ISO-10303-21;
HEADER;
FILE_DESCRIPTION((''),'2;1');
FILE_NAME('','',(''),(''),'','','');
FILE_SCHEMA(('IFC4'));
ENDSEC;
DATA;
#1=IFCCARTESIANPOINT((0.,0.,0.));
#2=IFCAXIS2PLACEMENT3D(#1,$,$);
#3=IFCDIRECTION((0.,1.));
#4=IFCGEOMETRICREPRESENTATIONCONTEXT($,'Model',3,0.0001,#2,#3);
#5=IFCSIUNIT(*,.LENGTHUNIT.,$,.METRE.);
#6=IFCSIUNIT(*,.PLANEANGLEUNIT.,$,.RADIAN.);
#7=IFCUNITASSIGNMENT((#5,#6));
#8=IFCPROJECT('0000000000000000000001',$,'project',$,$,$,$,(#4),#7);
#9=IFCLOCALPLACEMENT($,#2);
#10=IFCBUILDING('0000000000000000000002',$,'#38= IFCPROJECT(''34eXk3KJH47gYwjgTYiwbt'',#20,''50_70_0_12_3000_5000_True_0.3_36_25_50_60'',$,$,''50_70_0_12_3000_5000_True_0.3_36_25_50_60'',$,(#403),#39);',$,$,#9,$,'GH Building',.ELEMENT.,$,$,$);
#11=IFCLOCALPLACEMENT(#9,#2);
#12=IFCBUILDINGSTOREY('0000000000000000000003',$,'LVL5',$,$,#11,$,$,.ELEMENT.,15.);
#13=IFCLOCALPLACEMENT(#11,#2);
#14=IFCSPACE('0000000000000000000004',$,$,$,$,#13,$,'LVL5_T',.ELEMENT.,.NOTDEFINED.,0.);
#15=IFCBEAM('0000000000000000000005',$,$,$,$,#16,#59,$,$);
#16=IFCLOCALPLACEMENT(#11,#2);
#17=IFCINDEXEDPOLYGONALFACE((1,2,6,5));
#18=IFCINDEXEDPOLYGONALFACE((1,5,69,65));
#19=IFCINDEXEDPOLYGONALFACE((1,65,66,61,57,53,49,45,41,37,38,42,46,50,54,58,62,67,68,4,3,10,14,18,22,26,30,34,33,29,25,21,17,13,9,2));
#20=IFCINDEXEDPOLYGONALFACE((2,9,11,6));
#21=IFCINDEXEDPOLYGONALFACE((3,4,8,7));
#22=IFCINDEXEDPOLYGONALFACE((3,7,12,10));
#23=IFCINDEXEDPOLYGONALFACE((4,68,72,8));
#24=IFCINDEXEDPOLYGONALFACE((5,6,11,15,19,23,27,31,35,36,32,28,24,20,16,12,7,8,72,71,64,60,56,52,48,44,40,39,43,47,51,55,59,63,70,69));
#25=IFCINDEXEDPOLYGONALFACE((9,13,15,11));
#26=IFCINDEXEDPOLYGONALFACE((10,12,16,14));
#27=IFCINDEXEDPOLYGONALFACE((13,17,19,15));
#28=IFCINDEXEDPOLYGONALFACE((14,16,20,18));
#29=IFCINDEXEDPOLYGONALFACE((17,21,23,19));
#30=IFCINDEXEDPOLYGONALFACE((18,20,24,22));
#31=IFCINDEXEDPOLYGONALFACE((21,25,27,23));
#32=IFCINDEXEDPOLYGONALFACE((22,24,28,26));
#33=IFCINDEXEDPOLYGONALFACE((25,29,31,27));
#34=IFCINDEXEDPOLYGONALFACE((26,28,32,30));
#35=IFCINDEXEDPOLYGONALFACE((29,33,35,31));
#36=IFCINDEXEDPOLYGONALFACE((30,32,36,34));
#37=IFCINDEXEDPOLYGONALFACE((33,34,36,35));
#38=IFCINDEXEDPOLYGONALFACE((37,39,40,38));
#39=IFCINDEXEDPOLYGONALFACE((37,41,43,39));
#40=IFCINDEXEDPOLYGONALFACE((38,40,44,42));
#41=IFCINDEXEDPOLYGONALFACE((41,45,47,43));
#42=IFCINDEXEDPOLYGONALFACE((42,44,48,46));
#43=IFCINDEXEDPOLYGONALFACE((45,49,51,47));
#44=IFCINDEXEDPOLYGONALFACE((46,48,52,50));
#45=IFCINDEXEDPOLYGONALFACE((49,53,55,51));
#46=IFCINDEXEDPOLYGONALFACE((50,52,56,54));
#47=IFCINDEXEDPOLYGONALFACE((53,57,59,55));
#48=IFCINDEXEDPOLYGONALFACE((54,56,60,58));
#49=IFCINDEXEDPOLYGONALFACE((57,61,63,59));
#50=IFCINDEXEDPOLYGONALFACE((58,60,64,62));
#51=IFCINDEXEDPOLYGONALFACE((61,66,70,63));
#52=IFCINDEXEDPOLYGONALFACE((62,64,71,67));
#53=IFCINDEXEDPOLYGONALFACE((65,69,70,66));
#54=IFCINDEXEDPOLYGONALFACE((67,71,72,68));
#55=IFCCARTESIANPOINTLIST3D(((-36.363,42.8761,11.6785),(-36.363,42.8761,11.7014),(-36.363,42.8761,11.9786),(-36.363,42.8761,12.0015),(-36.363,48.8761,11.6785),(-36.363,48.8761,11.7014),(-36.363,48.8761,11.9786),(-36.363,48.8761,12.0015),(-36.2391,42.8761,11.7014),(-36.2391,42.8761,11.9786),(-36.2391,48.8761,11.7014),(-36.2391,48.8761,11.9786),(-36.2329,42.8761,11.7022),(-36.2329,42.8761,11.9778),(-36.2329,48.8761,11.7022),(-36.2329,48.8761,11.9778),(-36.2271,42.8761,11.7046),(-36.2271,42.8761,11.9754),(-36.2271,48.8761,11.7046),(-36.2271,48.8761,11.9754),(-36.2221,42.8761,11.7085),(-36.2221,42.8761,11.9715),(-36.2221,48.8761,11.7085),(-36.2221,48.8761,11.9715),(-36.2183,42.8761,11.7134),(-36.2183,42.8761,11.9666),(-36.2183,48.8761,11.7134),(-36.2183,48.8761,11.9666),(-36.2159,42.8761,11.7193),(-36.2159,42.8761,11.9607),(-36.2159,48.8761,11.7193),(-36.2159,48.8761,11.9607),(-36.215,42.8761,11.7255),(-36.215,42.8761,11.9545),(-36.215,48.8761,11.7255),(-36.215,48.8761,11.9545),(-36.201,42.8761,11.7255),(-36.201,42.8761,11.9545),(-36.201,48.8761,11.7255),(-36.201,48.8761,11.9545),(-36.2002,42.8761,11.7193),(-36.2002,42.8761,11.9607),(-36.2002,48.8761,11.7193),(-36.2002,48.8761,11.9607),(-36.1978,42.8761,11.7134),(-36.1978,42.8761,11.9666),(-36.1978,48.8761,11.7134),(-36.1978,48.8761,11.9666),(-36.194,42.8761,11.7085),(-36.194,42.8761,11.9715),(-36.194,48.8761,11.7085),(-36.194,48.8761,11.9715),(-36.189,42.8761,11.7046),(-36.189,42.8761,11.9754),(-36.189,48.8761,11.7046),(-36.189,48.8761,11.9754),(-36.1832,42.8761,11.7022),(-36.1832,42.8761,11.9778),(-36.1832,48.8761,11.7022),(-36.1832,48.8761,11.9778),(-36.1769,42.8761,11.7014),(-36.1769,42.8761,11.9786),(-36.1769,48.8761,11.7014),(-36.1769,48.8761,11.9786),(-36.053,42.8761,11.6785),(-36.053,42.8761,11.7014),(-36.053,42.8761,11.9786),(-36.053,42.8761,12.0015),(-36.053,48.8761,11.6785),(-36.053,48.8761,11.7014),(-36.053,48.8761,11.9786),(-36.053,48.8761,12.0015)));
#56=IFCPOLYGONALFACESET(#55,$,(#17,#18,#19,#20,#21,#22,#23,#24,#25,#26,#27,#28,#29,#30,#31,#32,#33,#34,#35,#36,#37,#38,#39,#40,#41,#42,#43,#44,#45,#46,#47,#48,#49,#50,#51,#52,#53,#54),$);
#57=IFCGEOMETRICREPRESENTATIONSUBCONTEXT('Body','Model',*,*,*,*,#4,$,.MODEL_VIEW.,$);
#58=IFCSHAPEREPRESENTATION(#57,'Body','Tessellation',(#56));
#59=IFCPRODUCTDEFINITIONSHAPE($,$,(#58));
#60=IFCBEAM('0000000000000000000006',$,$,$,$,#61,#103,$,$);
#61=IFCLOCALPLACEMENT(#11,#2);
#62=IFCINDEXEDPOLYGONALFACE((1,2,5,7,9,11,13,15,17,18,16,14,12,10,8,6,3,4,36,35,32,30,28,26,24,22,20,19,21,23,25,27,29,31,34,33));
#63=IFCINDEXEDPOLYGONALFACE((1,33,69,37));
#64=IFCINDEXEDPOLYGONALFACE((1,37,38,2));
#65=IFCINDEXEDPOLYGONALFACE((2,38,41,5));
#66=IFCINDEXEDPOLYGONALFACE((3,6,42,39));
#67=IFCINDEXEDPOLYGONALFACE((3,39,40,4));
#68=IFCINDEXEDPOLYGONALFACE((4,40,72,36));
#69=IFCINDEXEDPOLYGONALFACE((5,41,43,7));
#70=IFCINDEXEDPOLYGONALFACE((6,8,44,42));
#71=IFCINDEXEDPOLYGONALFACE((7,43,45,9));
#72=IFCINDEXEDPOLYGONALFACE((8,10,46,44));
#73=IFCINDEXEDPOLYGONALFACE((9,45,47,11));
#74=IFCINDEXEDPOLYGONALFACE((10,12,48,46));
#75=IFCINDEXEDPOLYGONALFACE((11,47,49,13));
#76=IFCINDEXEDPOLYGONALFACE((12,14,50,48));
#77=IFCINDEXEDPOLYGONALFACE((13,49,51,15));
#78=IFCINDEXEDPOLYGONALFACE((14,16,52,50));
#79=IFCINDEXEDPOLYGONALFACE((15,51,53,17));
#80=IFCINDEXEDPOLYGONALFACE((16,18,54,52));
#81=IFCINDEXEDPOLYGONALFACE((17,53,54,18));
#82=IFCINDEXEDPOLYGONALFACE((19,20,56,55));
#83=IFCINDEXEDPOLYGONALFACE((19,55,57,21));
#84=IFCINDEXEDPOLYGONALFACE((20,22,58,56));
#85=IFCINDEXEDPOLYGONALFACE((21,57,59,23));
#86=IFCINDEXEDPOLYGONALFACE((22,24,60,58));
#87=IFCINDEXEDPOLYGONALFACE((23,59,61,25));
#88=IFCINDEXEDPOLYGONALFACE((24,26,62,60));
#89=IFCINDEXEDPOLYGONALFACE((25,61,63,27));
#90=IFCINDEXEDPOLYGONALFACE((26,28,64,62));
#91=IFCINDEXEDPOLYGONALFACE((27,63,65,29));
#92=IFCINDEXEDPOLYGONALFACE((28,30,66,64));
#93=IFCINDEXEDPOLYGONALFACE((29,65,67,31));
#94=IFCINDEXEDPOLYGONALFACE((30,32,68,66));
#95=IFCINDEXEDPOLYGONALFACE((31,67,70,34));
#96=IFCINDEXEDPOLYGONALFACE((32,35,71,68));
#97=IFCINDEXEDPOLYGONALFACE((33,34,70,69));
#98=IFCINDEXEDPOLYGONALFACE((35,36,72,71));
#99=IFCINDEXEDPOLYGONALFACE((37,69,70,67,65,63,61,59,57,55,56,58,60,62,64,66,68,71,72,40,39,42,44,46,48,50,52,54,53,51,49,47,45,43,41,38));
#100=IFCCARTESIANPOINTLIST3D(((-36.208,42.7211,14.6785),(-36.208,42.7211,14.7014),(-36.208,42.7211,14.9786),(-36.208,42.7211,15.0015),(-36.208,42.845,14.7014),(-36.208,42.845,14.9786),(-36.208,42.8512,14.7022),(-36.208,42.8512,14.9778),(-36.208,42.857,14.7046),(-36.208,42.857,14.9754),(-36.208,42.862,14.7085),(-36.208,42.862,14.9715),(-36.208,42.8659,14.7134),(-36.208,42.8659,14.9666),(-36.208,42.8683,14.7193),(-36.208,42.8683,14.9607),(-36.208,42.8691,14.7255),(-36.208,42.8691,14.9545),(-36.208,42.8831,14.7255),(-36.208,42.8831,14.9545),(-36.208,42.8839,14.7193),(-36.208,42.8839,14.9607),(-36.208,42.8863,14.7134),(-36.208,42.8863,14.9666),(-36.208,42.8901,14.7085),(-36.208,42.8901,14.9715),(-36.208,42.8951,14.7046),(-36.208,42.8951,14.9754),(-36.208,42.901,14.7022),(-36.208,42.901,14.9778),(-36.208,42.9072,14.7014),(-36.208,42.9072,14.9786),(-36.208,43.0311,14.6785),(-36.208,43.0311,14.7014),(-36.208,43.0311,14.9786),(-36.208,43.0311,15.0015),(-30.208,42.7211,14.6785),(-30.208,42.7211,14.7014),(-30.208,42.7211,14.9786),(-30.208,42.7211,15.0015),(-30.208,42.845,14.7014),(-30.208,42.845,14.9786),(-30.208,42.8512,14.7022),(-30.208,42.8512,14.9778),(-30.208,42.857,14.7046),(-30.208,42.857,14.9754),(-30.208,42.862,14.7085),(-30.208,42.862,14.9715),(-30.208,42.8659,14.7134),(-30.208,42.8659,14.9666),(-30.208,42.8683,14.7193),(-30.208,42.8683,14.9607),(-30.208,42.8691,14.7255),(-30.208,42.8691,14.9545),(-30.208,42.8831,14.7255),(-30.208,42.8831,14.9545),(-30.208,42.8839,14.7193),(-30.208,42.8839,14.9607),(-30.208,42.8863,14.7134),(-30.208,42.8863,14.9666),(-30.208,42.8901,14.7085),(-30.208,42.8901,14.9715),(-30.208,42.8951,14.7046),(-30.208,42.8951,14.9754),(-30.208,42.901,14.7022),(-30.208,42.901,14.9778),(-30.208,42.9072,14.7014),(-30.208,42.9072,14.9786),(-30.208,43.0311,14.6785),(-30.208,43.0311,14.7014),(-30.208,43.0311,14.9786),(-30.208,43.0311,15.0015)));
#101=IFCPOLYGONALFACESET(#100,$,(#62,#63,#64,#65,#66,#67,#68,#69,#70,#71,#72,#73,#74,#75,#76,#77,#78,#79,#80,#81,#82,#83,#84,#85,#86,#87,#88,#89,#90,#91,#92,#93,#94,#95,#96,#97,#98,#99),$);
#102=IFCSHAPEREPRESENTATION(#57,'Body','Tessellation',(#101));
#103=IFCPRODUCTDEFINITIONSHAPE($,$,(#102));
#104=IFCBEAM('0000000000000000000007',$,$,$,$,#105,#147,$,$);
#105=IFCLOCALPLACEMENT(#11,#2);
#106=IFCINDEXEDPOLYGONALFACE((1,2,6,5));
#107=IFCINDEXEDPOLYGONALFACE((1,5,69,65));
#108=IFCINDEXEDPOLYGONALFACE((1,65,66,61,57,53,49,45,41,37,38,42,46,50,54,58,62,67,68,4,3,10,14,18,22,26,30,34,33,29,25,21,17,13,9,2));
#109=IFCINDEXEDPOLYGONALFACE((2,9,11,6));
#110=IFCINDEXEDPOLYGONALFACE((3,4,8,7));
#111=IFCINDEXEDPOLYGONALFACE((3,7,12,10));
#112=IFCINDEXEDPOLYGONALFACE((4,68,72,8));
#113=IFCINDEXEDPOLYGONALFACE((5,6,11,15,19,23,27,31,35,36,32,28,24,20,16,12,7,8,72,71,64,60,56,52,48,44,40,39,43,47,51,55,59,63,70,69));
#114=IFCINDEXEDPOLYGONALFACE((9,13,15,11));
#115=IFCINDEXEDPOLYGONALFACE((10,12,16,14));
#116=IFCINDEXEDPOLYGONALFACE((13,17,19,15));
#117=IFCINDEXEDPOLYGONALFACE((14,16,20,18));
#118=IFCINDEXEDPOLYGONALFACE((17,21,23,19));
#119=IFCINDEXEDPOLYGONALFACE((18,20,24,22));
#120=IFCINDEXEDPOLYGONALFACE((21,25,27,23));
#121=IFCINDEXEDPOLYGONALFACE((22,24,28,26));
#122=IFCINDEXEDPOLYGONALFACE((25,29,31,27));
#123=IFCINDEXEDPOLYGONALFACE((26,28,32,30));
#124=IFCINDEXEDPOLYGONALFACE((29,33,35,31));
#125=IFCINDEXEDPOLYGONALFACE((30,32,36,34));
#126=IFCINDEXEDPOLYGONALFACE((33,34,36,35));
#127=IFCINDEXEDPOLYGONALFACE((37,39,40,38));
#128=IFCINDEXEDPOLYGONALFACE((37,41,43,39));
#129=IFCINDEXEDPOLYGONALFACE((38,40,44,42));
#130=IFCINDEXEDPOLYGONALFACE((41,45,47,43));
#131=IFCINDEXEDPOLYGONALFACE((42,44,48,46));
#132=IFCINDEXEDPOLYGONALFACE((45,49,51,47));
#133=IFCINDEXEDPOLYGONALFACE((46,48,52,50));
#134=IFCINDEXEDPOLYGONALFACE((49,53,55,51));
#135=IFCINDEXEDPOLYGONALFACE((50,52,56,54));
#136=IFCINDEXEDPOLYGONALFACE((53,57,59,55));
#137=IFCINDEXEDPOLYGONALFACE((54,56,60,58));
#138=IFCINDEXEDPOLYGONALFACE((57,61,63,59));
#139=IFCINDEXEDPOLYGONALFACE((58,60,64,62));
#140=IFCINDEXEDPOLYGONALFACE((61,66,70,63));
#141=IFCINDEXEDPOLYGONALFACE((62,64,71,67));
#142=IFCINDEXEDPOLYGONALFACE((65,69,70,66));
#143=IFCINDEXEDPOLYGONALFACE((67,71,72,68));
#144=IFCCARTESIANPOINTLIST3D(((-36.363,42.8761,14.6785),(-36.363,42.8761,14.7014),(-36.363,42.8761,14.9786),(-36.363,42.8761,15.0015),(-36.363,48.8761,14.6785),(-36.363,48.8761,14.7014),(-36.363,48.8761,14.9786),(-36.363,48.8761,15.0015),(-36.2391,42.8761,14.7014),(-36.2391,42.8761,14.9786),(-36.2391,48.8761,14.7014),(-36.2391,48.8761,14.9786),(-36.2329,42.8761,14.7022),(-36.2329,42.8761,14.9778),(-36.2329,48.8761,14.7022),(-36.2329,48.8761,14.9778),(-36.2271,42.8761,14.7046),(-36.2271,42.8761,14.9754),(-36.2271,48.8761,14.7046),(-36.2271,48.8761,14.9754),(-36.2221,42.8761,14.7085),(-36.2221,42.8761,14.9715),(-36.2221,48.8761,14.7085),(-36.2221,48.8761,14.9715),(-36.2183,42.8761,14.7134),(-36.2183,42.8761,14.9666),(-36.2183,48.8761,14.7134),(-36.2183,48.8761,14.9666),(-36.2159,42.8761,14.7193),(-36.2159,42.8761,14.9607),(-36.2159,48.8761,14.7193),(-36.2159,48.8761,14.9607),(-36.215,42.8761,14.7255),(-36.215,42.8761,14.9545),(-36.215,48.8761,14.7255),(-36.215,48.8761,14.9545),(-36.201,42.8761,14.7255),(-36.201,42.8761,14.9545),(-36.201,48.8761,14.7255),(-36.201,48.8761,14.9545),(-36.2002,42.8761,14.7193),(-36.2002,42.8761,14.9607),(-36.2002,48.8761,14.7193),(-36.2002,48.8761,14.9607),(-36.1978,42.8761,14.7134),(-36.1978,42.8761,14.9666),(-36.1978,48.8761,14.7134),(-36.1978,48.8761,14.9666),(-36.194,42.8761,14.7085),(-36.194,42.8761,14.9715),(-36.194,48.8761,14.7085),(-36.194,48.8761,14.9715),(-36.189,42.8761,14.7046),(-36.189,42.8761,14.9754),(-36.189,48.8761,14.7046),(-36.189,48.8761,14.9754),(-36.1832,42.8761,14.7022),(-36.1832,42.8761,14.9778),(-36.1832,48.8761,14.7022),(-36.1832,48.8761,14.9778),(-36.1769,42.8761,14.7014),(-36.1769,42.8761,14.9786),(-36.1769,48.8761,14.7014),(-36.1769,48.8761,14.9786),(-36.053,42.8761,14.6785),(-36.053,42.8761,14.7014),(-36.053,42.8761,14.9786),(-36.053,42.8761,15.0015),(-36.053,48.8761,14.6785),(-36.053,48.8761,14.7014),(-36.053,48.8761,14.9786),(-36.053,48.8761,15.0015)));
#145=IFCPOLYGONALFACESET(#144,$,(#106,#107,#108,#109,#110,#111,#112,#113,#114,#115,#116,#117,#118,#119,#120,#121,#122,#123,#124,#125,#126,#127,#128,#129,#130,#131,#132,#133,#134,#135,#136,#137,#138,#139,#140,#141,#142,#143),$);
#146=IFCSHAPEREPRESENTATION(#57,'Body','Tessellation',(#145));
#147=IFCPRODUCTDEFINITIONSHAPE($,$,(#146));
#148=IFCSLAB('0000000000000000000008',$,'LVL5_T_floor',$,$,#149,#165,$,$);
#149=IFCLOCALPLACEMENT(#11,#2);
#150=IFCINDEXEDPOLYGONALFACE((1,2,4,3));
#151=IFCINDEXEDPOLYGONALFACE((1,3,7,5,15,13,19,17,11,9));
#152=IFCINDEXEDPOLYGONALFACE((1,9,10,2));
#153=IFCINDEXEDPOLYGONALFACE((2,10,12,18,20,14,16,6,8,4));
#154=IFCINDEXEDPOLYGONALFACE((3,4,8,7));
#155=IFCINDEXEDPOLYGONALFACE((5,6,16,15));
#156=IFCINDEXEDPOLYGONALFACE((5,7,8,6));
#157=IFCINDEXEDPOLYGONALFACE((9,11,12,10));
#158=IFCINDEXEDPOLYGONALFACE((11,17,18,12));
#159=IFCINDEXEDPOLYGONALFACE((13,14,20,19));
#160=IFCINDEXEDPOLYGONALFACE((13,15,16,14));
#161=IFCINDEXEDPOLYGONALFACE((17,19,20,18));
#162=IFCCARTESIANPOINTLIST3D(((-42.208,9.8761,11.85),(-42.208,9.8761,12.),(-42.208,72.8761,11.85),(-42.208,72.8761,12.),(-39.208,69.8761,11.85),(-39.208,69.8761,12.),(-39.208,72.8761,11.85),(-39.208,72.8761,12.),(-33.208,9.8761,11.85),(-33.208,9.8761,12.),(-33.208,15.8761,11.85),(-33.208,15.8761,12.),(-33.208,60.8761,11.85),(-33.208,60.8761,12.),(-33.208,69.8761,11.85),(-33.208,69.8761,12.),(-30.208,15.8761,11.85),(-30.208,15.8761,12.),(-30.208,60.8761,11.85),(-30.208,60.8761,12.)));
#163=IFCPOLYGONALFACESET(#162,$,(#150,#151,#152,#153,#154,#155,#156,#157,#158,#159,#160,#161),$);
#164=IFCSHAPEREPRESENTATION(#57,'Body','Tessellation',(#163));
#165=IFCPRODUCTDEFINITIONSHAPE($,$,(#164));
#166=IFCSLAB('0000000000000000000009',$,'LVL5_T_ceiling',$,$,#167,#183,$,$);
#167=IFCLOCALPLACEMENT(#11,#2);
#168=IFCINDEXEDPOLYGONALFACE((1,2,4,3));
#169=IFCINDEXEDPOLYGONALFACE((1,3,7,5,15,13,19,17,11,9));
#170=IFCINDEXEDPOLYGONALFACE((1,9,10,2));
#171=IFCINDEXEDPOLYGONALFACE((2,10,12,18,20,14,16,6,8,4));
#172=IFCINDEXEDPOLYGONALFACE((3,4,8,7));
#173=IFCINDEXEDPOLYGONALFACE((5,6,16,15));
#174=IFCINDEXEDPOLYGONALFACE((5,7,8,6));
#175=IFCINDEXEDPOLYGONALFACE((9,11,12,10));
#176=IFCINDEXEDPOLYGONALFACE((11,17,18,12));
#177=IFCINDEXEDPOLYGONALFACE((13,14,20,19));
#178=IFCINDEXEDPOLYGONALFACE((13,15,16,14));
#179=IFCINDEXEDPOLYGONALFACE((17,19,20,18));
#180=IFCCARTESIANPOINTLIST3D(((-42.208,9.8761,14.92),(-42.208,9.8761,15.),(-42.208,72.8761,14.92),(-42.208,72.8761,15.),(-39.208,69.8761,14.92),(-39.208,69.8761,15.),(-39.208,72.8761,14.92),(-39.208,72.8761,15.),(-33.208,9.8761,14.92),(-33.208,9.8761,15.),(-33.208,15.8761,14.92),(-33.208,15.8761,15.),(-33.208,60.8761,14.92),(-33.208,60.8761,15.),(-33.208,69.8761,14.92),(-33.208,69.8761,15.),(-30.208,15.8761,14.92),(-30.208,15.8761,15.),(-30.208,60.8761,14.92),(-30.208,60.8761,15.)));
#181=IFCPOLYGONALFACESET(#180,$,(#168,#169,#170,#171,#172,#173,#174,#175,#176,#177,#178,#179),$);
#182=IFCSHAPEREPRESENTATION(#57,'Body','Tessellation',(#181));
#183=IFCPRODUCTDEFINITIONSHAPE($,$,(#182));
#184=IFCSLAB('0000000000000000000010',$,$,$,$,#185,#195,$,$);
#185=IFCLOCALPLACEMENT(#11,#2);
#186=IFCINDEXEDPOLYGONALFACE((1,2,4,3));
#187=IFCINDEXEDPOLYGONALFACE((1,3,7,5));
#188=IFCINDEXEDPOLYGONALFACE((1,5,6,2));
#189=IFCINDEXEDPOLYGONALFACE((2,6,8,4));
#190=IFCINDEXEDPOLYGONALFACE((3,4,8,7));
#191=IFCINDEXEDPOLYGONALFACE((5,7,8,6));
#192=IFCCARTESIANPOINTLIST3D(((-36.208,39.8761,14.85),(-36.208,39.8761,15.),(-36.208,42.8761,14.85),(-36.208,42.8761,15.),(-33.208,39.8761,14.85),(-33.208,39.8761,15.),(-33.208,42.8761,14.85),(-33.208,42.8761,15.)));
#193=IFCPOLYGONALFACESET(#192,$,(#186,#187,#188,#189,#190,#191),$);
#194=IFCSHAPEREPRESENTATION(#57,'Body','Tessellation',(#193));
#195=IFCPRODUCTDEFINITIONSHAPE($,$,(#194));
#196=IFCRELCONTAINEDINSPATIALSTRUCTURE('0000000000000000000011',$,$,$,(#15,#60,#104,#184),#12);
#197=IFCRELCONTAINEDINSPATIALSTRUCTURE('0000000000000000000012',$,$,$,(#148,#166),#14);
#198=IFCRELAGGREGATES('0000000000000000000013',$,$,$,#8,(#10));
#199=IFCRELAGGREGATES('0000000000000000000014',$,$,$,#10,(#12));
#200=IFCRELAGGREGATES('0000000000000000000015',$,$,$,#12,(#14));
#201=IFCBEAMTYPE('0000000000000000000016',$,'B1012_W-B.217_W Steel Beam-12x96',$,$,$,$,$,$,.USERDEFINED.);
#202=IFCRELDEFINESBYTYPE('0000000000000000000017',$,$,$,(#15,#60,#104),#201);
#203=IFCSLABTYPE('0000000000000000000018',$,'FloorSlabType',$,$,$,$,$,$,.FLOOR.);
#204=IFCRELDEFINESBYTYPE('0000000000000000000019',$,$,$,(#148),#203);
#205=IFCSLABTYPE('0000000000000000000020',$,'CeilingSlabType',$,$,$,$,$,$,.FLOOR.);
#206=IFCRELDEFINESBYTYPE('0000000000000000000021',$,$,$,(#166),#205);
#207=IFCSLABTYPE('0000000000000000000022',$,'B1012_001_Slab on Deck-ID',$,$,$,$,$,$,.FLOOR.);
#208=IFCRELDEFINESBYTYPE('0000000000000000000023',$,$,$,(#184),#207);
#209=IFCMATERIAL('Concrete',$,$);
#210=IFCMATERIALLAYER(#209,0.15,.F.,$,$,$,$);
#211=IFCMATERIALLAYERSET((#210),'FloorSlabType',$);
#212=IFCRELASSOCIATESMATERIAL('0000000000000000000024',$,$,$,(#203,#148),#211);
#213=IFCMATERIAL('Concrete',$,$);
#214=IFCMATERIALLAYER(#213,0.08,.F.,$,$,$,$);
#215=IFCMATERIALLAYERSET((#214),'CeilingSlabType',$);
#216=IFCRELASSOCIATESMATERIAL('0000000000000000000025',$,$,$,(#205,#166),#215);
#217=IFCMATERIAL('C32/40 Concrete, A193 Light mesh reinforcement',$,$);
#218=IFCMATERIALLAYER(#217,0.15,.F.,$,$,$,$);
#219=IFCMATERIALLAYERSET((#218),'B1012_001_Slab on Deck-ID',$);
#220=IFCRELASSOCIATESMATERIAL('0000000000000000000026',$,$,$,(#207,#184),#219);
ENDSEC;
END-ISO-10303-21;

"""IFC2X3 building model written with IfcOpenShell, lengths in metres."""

from ifc_helpers import new_model, si_unit, direction, frame, origin, origin_2d, place, context, subcontext, project, spatial, polyline, i_section, outline, extrude, material, layer, layer_set, layer_usage, type_object, element, save


model = new_model("IFC2X3")

# Units and contexts
model_context = context("Model", 3, precision=0.0001, world=origin(), true_north=direction((0.0, 1.0)))
body_context = subcontext(model_context, "Body", "Model", "MODEL_VIEW")
ifc_project = project(units=[si_unit("LENGTHUNIT", "METRE"), si_unit("PLANEANGLEUNIT", "RADIAN")], contexts=[model_context])

# Building, storey, space
building_placement = place(None, origin())
building = spatial("IfcBuilding", under=ifc_project, at=building_placement, Name="#38= IFCPROJECT('34eXk3KJH47gYwjgTYiwbt',#20,'50_70_0_12_3000_5000_True_0.3_36_25_50_60',$,$,'50_70_0_12_3000_5000_True_0.3_36_25_50_60',$,(#403),#39);", LongName="GH Building", CompositionType="ELEMENT")
storey_placement = place(building_placement, origin())
storey = spatial("IfcBuildingStorey", under=building, at=storey_placement, Name="LVL5", CompositionType="ELEMENT", Elevation=15.0)
space_1_placement = place(storey_placement, origin())
space_1 = spatial("IfcSpace", under=storey, at=space_1_placement, LongName="LVL5_T", CompositionType="ELEMENT", InteriorOrExteriorSpace="NOTDEFINED", ElevationWithFlooring=0.0)

# Beams
beam_type = type_object("IfcBeamType", Name="B1012_W-B.217_W Steel Beam-12x96", PredefinedType="USERDEFINED")
for number, where, z_axis, x_axis in (
    (1, (-36.208, 42.8761, 11.84), (0.0, 1.0, 0.0), (-1.0, 0.0, 0.0)),
    (2, (-36.208, 42.8761, 14.84), (1.0, 0.0, 0.0), (0.0, 1.0, 0.0)),
    (3, (-36.208, 42.8761, 14.84), (0.0, 1.0, 0.0), (-1.0, 0.0, 0.0)),
):
    element("IfcBeam", number, at=place(storey_placement, frame(where, z_axis=z_axis, x_axis=x_axis)), inside=storey, type_object=beam_type, context=body_context, shape_type="SweptSolid", body=[
        extrude(i_section(OverallWidth=0.31, OverallDepth=0.323, WebThickness=0.014, FlangeThickness=0.0229, FilletRadius=0.0241, at=origin_2d()), origin(), (0.0, 0.0, 1.0), 6.0),
    ])

# Slabs
ifc_material_1 = material(Name="Concrete")
ifc_layer_1 = layer(ifc_material_1, 0.15, ventilated=False)
ifc_layer_set_1 = layer_set([ifc_layer_1], Name="FloorSlabType")
ifc_layer_usage_1 = layer_usage(ifc_layer_set_1, "AXIS3", "NEGATIVE", -0.15)
slab_type_1 = type_object("IfcSlabType", Name="FloorSlabType", PredefinedType="FLOOR", material=ifc_layer_set_1)
slab_1_placement = place(space_1_placement, frame((-36.208, 41.3761, 11.85)))
element("IfcSlab", 4, at=slab_1_placement, inside=space_1, type_object=slab_type_1, material=ifc_layer_usage_1, Name="LVL5_T_floor", context=body_context, shape_type="SweptSolid", body=[
    extrude(outline(polyline([(-3.0, 28.5), (-3.0, 31.5), (-6.0, 31.5), (-6.0, -31.5), (3.0, -31.5), (3.0, -25.5), (6.0, -25.5), (6.0, 19.5), (3.0, 19.5), (3.0, 28.5), (-3.0, 28.5)])), origin(), (0.0, 0.0, 1.0), 0.15),
])
ifc_material_2 = material(Name="Concrete")
ifc_layer_2 = layer(ifc_material_2, 0.08, ventilated=False)
ifc_layer_set_2 = layer_set([ifc_layer_2], Name="CeilingSlabType")
ifc_layer_usage_2 = layer_usage(ifc_layer_set_2, "AXIS3", "NEGATIVE", -0.08)
slab_type_2 = type_object("IfcSlabType", Name="CeilingSlabType", PredefinedType="FLOOR", material=ifc_layer_set_2)
slab_2_placement = place(space_1_placement, frame((-36.208, 41.3761, 14.92)))
element("IfcSlab", 5, at=slab_2_placement, inside=space_1, type_object=slab_type_2, material=ifc_layer_usage_2, Name="LVL5_T_ceiling", context=body_context, shape_type="SweptSolid", body=[
    extrude(outline(polyline([(-3.0, 28.5), (-3.0, 31.5), (-6.0, 31.5), (-6.0, -31.5), (3.0, -31.5), (3.0, -25.5), (6.0, -25.5), (6.0, 19.5), (3.0, 19.5), (3.0, 28.5), (-3.0, 28.5)])), origin(), (0.0, 0.0, 1.0), 0.08),
])
ifc_material_3 = material(Name="C32/40 Concrete, A193 Light mesh reinforcement")
ifc_layer_3 = layer(ifc_material_3, 0.15, ventilated=False)
ifc_layer_set_3 = layer_set([ifc_layer_3], Name="B1012_001_Slab on Deck-ID")
ifc_layer_usage_3 = layer_usage(ifc_layer_set_3, "AXIS3", "NEGATIVE", -0.15)
slab_type_3 = type_object("IfcSlabType", Name="B1012_001_Slab on Deck-ID", PredefinedType="FLOOR", material=ifc_layer_set_3)
slab_3_placement = place(storey_placement, frame((-34.708, 41.3761, 14.85)))
element("IfcSlab", 6, at=slab_3_placement, inside=storey, type_object=slab_type_3, material=ifc_layer_usage_3, context=body_context, shape_type="SweptSolid", body=[
    extrude(outline(polyline([(-1.5, 1.5), (1.5, 1.5), (1.5, -1.5), (-1.5, -1.5), (-1.5, 1.5)])), origin(), (0.0, 0.0, 1.0), 0.15),
])

save(model, "model.ifc")
